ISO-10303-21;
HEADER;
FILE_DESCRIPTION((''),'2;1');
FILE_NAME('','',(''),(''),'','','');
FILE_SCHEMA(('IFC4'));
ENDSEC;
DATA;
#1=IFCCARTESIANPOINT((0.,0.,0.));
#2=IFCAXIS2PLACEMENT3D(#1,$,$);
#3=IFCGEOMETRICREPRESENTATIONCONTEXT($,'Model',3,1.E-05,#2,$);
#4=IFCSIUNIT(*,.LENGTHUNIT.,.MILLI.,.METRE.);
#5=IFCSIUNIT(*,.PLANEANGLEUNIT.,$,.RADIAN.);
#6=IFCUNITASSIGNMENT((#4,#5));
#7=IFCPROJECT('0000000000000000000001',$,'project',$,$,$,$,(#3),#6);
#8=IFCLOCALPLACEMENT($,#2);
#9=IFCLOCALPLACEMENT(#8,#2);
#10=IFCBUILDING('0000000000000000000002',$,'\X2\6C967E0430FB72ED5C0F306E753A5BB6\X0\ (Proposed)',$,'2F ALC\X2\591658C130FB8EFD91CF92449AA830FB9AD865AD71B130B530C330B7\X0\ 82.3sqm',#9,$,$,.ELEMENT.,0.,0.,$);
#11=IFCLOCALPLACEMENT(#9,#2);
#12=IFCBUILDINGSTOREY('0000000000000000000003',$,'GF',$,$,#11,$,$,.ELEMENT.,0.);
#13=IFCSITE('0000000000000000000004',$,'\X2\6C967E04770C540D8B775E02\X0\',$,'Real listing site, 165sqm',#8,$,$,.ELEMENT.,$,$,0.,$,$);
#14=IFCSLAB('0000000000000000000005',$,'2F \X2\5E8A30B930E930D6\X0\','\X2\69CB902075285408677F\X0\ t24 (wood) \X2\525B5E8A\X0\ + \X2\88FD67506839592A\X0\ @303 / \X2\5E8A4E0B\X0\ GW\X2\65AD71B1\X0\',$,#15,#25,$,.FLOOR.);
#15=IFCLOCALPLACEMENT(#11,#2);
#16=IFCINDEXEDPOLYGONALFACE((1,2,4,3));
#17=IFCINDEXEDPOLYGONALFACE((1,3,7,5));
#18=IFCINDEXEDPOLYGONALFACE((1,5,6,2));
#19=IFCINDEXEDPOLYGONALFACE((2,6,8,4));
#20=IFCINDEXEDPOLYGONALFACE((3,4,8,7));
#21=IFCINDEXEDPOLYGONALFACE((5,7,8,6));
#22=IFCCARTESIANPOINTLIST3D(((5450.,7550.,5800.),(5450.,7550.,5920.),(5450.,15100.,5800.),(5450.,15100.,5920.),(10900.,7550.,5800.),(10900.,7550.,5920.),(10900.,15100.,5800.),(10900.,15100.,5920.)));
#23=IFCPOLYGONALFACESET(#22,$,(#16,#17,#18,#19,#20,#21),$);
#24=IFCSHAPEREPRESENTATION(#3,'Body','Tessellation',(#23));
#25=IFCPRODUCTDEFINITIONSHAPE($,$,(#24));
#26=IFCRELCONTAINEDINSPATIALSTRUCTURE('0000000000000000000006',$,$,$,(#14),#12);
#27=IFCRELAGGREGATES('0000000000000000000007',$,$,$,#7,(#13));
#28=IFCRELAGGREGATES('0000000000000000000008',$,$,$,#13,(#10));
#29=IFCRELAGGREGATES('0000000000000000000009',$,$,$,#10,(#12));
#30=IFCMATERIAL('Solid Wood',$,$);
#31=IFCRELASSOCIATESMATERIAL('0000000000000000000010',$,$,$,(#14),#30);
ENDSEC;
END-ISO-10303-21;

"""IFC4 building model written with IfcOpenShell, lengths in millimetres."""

from ifc_helpers import new_model, si_unit, frame, frame_2d, origin, place, context, project, spatial, rectangle, extrude, material, element, save


model = new_model("IFC4")

# Units and contexts
model_context = context("Model", 3, precision=1e-05, world=origin())
ifc_project = project(units=[si_unit("LENGTHUNIT", "METRE", prefix="MILLI"), si_unit("PLANEANGLEUNIT", "RADIAN")], contexts=[model_context])

# Site, building, storey
site_placement = place(None, origin())
site = spatial("IfcSite", under=ifc_project, at=site_placement, Name="沖縄県名護市", ObjectType="Real listing site, 165sqm", CompositionType="ELEMENT", RefElevation=0.0)
building_placement = place(site_placement, origin())
building = spatial("IfcBuilding", under=site, at=building_placement, Name="沖縄・狭小の町家 (Proposed)", ObjectType="2F ALC外壁・軽量鉄骨・高断熱サッシ 82.3sqm", CompositionType="ELEMENT", ElevationOfRefHeight=0.0, ElevationOfTerrain=0.0)
storey_placement = place(building_placement, origin())
storey = spatial("IfcBuildingStorey", under=building, at=storey_placement, Name="GF", CompositionType="ELEMENT", Elevation=0.0)

# Shared definitions
ifc_material_1 = material(Name="Solid Wood")

# Slab
slab_placement = place(storey_placement, frame((2725.0, 3775.0, 2900.0)))
element("IfcSlab", 1, at=slab_placement, inside=storey, material=ifc_material_1, Name="2F 床スラブ", Description="構造用合板 t24 (wood) 剛床 + 製材根太 @303 / 床下 GW断熱", PredefinedType="FLOOR", context=model_context, shape_type="SweptSolid", body=[
    extrude(rectangle(XDim=5450.0, YDim=7550.0, at=frame_2d((2725.0, 3775.0))), frame((2725.0, 3775.0, 2900.0)), (0.0, 0.0, 1.0), 120.0),
])

save(model, "model.ifc")
